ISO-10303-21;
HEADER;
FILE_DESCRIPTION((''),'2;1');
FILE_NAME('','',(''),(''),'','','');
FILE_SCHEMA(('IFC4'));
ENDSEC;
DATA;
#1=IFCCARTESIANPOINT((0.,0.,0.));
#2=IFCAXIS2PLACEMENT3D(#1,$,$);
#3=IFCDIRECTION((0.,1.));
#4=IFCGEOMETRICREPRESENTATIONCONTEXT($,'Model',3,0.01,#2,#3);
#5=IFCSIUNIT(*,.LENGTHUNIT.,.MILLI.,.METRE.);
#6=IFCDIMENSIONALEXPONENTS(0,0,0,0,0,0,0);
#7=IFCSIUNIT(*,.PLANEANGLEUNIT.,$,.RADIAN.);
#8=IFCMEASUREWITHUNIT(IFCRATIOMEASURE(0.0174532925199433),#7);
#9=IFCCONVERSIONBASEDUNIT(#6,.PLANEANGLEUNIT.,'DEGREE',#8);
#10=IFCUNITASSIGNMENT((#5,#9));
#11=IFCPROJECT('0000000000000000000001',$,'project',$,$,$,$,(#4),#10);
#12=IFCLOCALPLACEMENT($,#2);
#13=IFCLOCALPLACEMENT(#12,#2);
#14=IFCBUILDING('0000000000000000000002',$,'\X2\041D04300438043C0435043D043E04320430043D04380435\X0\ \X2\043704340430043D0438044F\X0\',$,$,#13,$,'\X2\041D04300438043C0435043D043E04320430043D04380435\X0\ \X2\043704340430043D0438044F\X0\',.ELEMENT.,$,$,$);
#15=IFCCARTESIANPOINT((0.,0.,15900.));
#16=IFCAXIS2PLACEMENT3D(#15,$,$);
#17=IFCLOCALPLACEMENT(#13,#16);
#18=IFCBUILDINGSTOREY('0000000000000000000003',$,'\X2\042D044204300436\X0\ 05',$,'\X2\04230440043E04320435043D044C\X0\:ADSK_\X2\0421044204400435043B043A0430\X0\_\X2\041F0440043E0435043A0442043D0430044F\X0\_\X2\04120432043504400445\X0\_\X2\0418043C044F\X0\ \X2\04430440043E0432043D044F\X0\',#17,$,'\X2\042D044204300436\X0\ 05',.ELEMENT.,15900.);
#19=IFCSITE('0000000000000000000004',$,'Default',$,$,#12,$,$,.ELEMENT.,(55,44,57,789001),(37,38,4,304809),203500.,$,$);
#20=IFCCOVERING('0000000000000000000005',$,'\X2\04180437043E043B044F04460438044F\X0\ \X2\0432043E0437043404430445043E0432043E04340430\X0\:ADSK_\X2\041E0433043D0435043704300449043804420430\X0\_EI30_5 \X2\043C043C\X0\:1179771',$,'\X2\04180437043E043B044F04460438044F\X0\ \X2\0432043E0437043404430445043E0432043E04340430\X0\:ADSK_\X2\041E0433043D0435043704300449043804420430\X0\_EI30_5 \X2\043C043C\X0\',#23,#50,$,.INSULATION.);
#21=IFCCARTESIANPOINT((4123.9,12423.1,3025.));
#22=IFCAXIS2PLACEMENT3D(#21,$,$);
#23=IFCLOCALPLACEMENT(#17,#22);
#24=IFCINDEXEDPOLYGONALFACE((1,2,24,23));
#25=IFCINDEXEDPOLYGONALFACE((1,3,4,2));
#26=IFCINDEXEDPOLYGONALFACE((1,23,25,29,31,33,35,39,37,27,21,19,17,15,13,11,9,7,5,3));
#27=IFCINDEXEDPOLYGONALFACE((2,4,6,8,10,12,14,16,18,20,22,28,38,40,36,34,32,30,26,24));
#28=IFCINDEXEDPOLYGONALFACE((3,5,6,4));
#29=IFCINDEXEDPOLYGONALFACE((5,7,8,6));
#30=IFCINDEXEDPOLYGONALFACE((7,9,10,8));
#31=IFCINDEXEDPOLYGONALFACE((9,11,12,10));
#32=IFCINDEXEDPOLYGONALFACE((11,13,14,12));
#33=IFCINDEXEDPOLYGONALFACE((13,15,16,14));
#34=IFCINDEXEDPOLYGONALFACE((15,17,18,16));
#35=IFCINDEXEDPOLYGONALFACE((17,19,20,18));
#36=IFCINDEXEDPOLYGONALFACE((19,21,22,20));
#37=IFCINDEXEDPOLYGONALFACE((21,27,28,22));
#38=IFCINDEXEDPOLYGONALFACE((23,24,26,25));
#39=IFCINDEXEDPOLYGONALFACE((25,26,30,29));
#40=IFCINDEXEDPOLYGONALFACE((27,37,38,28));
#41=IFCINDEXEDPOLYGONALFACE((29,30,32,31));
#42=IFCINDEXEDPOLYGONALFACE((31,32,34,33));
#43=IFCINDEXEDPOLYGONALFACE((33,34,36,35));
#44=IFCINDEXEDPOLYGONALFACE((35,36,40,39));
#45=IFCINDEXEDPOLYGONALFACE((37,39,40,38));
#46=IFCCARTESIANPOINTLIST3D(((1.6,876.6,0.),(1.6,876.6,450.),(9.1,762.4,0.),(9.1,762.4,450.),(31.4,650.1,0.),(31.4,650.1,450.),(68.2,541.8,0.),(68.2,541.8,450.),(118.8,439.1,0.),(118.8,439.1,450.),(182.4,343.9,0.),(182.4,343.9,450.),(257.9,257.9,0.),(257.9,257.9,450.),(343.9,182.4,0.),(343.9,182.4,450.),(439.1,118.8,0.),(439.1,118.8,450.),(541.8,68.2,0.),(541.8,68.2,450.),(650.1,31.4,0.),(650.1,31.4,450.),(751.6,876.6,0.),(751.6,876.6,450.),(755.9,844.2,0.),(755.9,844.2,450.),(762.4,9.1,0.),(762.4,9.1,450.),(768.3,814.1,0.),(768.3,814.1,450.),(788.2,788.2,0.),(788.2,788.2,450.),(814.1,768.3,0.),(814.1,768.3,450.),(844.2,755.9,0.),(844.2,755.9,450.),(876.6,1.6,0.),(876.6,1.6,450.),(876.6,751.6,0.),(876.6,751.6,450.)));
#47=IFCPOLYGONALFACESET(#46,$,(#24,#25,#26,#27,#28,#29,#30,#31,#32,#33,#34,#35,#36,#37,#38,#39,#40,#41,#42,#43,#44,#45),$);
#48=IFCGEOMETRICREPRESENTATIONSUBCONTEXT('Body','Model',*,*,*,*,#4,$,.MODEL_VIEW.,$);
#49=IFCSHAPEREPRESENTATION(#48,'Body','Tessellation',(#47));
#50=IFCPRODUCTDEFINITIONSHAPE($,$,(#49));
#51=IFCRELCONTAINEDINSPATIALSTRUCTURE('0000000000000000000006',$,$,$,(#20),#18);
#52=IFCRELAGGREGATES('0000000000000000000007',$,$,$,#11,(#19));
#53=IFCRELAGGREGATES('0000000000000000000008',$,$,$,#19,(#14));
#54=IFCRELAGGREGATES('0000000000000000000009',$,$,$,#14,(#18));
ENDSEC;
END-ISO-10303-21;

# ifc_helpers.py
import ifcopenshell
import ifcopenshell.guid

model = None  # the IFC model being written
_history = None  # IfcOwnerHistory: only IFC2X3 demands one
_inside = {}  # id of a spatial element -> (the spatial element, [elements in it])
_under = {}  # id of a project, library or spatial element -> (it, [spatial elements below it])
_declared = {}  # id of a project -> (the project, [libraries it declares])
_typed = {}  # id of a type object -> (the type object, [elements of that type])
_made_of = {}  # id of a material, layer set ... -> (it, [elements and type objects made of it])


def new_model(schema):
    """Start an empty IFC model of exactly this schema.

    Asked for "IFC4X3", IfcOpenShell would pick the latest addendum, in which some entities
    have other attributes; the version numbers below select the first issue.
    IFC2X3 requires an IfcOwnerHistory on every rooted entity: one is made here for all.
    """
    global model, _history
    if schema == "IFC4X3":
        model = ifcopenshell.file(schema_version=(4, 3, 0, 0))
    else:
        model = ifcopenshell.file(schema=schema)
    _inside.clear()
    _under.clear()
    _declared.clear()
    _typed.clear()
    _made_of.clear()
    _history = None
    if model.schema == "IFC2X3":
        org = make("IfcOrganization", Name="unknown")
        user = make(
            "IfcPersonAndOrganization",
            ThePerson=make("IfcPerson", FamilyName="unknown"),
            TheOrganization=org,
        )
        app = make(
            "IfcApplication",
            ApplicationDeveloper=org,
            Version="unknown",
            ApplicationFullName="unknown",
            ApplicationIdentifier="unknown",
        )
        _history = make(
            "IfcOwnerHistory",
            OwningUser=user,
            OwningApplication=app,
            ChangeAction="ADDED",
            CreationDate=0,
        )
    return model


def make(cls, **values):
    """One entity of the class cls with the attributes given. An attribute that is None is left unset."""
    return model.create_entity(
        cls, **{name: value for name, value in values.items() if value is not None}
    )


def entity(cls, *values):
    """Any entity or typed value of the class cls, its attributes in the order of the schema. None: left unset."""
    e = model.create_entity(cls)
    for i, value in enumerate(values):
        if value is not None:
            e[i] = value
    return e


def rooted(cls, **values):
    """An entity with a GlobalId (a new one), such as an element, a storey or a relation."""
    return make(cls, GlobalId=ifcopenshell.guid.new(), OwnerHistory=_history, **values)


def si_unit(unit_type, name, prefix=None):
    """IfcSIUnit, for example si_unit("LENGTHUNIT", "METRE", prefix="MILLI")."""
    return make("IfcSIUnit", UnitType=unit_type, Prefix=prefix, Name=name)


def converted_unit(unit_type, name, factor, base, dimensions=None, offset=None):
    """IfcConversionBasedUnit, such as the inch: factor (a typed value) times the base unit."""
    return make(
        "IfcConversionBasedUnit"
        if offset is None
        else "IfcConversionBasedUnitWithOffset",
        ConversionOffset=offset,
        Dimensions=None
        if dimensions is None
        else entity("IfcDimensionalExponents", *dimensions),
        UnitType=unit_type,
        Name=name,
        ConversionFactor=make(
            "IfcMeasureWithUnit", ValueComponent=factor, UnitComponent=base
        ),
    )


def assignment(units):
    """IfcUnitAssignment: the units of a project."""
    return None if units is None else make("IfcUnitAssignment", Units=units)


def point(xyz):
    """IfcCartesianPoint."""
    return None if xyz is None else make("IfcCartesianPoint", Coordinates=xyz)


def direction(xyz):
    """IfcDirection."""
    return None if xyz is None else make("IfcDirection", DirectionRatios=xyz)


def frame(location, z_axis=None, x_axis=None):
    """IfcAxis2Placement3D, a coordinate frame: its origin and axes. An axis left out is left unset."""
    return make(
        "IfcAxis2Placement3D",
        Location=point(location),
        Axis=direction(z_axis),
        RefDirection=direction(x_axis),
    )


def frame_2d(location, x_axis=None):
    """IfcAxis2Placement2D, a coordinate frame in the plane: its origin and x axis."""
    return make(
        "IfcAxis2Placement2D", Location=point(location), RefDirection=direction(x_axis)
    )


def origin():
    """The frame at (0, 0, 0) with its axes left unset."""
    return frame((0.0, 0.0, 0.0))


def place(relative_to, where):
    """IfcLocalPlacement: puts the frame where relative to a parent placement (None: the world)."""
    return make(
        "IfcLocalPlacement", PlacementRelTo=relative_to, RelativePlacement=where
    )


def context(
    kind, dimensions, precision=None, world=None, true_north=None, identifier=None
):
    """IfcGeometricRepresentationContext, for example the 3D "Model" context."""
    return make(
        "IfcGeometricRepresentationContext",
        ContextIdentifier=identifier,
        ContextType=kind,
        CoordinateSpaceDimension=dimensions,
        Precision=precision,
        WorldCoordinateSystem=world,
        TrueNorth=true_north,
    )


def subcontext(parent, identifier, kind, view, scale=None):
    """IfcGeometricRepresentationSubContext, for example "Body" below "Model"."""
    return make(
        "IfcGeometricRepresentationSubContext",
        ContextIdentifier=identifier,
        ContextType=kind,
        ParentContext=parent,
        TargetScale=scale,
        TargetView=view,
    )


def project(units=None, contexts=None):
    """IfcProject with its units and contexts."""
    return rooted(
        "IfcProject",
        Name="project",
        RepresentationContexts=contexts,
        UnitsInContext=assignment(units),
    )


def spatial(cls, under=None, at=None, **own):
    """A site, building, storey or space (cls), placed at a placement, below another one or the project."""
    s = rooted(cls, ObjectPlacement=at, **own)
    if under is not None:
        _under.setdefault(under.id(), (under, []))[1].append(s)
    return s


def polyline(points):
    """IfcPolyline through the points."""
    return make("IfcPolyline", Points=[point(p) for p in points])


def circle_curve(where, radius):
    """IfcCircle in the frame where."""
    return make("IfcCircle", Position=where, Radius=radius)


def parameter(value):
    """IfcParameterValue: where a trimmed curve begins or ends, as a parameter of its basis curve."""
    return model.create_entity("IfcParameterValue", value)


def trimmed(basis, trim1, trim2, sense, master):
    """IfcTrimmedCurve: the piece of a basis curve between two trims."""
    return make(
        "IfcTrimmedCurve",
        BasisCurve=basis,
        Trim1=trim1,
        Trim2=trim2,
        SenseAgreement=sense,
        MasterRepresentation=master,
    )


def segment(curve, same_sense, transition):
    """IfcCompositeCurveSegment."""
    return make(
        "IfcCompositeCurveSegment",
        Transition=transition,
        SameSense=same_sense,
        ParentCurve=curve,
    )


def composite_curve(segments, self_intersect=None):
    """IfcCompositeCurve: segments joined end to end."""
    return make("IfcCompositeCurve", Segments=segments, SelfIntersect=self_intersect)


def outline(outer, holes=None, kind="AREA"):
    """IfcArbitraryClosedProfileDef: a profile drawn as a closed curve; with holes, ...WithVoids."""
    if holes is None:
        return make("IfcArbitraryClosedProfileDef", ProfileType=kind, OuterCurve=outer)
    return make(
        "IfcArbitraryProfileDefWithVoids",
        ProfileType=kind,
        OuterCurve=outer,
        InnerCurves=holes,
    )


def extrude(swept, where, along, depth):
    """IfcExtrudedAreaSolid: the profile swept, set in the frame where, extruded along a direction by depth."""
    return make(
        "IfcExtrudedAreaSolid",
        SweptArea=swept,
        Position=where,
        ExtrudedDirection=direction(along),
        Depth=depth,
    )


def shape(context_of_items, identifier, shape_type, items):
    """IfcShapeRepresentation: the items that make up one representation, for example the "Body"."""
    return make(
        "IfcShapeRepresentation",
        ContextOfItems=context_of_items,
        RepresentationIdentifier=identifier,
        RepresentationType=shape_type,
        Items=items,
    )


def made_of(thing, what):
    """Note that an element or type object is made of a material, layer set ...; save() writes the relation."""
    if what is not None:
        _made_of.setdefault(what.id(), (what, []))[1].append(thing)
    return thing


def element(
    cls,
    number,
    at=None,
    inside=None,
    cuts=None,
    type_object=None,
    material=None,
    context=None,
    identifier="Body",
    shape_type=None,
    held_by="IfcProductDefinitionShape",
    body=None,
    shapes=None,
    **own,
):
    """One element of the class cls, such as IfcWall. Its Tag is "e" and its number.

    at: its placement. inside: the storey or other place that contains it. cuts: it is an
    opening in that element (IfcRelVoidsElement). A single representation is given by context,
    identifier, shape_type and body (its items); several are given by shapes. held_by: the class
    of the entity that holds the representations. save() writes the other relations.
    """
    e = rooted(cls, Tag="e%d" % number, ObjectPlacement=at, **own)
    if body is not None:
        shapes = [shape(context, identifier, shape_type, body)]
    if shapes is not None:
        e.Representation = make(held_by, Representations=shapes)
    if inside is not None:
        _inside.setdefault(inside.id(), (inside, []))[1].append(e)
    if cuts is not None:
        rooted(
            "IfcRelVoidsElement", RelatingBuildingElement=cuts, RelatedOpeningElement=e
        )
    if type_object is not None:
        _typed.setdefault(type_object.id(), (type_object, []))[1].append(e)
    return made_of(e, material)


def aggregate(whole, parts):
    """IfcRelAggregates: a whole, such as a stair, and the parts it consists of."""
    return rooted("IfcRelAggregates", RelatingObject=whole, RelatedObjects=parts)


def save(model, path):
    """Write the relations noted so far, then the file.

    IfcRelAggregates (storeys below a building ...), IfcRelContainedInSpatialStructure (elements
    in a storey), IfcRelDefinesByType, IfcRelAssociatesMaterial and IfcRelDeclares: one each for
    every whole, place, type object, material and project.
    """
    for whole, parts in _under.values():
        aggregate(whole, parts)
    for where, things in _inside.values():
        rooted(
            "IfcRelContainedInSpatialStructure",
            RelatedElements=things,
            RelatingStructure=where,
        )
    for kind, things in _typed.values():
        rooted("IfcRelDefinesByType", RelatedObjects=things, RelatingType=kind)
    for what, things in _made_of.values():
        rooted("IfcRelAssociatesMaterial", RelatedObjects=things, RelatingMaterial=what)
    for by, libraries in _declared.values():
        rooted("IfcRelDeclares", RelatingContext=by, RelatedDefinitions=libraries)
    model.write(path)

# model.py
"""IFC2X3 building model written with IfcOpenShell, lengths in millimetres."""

from ifc_helpers import new_model, entity, si_unit, converted_unit, direction, frame, frame_2d, origin, place, context, subcontext, project, spatial, polyline, circle_curve, parameter, trimmed, segment, composite_curve, outline, extrude, element, save


model = new_model("IFC2X3")

# Units and contexts
model_context = context("Model", 3, precision=0.01, world=origin(), true_north=direction((0.0, 1.0)))
body_context = subcontext(model_context, "Body", "Model", "MODEL_VIEW")
ifc_project = project(units=[si_unit("LENGTHUNIT", "METRE", prefix="MILLI"), converted_unit("PLANEANGLEUNIT", "DEGREE", entity("IfcRatioMeasure", 0.0174532925199433), si_unit("PLANEANGLEUNIT", "RADIAN"), dimensions=[0, 0, 0, 0, 0, 0, 0])], contexts=[model_context])

# Site, building, storey
site_placement = place(None, origin())
site = spatial("IfcSite", under=ifc_project, at=site_placement, Name="Default", CompositionType="ELEMENT", RefLatitude=(55, 44, 57, 789001), RefLongitude=(37, 38, 4, 304809), RefElevation=203500.0)
building_placement = place(site_placement, origin())
building = spatial("IfcBuilding", under=site, at=building_placement, Name="Наименование здания", LongName="Наименование здания", CompositionType="ELEMENT")
storey_placement = place(building_placement, frame((0.0, 0.0, 15900.0)))
storey = spatial("IfcBuildingStorey", under=building, at=storey_placement, Name="Этаж 05", ObjectType="Уровень:ADSK_Стрелка_Проектная_Вверх_Имя уровня", LongName="Этаж 05", CompositionType="ELEMENT", Elevation=15900.0)

# Covering
covering_1_placement = place(storey_placement, frame((4123.9, 12423.1, 3025.0)))
element("IfcCovering", 1, at=covering_1_placement, inside=storey, Name="Изоляция воздуховода:ADSK_Огнезащита_EI30_5 мм:1179771", ObjectType="Изоляция воздуховода:ADSK_Огнезащита_EI30_5 мм", PredefinedType="INSULATION", context=body_context, shape_type="SweptSolid", body=[
    extrude(outline(composite_curve([segment(polyline([(-250.0, 125.0), (-250.0, -625.0)]), True, "CONTINUOUS"), segment(trimmed(circle_curve(frame_2d((-250.0, 250.0), x_axis=(1.0, 0.0)), 875.0), [parameter(270.0)], [parameter(0.0)], True, "PARAMETER"), True, "CONTINUOUS"), segment(polyline([(625.0, 250.0), (-125.0, 250.0)]), True, "CONTINUOUS"), segment(trimmed(circle_curve(frame_2d((-250.0, 250.0), x_axis=(1.0, 0.0)), 125.0), [parameter(270.0)], [parameter(360.0)], True, "PARAMETER"), False, "CONTINUOUS")], self_intersect=False)), frame((626.6, 626.6, 0.0), z_axis=(0.0, 0.0, -1.0), x_axis=(-1.0, 0.0, 0.0)), (0.0, 0.0, -1.0), 450.0),
])

save(model, "model.ifc")
